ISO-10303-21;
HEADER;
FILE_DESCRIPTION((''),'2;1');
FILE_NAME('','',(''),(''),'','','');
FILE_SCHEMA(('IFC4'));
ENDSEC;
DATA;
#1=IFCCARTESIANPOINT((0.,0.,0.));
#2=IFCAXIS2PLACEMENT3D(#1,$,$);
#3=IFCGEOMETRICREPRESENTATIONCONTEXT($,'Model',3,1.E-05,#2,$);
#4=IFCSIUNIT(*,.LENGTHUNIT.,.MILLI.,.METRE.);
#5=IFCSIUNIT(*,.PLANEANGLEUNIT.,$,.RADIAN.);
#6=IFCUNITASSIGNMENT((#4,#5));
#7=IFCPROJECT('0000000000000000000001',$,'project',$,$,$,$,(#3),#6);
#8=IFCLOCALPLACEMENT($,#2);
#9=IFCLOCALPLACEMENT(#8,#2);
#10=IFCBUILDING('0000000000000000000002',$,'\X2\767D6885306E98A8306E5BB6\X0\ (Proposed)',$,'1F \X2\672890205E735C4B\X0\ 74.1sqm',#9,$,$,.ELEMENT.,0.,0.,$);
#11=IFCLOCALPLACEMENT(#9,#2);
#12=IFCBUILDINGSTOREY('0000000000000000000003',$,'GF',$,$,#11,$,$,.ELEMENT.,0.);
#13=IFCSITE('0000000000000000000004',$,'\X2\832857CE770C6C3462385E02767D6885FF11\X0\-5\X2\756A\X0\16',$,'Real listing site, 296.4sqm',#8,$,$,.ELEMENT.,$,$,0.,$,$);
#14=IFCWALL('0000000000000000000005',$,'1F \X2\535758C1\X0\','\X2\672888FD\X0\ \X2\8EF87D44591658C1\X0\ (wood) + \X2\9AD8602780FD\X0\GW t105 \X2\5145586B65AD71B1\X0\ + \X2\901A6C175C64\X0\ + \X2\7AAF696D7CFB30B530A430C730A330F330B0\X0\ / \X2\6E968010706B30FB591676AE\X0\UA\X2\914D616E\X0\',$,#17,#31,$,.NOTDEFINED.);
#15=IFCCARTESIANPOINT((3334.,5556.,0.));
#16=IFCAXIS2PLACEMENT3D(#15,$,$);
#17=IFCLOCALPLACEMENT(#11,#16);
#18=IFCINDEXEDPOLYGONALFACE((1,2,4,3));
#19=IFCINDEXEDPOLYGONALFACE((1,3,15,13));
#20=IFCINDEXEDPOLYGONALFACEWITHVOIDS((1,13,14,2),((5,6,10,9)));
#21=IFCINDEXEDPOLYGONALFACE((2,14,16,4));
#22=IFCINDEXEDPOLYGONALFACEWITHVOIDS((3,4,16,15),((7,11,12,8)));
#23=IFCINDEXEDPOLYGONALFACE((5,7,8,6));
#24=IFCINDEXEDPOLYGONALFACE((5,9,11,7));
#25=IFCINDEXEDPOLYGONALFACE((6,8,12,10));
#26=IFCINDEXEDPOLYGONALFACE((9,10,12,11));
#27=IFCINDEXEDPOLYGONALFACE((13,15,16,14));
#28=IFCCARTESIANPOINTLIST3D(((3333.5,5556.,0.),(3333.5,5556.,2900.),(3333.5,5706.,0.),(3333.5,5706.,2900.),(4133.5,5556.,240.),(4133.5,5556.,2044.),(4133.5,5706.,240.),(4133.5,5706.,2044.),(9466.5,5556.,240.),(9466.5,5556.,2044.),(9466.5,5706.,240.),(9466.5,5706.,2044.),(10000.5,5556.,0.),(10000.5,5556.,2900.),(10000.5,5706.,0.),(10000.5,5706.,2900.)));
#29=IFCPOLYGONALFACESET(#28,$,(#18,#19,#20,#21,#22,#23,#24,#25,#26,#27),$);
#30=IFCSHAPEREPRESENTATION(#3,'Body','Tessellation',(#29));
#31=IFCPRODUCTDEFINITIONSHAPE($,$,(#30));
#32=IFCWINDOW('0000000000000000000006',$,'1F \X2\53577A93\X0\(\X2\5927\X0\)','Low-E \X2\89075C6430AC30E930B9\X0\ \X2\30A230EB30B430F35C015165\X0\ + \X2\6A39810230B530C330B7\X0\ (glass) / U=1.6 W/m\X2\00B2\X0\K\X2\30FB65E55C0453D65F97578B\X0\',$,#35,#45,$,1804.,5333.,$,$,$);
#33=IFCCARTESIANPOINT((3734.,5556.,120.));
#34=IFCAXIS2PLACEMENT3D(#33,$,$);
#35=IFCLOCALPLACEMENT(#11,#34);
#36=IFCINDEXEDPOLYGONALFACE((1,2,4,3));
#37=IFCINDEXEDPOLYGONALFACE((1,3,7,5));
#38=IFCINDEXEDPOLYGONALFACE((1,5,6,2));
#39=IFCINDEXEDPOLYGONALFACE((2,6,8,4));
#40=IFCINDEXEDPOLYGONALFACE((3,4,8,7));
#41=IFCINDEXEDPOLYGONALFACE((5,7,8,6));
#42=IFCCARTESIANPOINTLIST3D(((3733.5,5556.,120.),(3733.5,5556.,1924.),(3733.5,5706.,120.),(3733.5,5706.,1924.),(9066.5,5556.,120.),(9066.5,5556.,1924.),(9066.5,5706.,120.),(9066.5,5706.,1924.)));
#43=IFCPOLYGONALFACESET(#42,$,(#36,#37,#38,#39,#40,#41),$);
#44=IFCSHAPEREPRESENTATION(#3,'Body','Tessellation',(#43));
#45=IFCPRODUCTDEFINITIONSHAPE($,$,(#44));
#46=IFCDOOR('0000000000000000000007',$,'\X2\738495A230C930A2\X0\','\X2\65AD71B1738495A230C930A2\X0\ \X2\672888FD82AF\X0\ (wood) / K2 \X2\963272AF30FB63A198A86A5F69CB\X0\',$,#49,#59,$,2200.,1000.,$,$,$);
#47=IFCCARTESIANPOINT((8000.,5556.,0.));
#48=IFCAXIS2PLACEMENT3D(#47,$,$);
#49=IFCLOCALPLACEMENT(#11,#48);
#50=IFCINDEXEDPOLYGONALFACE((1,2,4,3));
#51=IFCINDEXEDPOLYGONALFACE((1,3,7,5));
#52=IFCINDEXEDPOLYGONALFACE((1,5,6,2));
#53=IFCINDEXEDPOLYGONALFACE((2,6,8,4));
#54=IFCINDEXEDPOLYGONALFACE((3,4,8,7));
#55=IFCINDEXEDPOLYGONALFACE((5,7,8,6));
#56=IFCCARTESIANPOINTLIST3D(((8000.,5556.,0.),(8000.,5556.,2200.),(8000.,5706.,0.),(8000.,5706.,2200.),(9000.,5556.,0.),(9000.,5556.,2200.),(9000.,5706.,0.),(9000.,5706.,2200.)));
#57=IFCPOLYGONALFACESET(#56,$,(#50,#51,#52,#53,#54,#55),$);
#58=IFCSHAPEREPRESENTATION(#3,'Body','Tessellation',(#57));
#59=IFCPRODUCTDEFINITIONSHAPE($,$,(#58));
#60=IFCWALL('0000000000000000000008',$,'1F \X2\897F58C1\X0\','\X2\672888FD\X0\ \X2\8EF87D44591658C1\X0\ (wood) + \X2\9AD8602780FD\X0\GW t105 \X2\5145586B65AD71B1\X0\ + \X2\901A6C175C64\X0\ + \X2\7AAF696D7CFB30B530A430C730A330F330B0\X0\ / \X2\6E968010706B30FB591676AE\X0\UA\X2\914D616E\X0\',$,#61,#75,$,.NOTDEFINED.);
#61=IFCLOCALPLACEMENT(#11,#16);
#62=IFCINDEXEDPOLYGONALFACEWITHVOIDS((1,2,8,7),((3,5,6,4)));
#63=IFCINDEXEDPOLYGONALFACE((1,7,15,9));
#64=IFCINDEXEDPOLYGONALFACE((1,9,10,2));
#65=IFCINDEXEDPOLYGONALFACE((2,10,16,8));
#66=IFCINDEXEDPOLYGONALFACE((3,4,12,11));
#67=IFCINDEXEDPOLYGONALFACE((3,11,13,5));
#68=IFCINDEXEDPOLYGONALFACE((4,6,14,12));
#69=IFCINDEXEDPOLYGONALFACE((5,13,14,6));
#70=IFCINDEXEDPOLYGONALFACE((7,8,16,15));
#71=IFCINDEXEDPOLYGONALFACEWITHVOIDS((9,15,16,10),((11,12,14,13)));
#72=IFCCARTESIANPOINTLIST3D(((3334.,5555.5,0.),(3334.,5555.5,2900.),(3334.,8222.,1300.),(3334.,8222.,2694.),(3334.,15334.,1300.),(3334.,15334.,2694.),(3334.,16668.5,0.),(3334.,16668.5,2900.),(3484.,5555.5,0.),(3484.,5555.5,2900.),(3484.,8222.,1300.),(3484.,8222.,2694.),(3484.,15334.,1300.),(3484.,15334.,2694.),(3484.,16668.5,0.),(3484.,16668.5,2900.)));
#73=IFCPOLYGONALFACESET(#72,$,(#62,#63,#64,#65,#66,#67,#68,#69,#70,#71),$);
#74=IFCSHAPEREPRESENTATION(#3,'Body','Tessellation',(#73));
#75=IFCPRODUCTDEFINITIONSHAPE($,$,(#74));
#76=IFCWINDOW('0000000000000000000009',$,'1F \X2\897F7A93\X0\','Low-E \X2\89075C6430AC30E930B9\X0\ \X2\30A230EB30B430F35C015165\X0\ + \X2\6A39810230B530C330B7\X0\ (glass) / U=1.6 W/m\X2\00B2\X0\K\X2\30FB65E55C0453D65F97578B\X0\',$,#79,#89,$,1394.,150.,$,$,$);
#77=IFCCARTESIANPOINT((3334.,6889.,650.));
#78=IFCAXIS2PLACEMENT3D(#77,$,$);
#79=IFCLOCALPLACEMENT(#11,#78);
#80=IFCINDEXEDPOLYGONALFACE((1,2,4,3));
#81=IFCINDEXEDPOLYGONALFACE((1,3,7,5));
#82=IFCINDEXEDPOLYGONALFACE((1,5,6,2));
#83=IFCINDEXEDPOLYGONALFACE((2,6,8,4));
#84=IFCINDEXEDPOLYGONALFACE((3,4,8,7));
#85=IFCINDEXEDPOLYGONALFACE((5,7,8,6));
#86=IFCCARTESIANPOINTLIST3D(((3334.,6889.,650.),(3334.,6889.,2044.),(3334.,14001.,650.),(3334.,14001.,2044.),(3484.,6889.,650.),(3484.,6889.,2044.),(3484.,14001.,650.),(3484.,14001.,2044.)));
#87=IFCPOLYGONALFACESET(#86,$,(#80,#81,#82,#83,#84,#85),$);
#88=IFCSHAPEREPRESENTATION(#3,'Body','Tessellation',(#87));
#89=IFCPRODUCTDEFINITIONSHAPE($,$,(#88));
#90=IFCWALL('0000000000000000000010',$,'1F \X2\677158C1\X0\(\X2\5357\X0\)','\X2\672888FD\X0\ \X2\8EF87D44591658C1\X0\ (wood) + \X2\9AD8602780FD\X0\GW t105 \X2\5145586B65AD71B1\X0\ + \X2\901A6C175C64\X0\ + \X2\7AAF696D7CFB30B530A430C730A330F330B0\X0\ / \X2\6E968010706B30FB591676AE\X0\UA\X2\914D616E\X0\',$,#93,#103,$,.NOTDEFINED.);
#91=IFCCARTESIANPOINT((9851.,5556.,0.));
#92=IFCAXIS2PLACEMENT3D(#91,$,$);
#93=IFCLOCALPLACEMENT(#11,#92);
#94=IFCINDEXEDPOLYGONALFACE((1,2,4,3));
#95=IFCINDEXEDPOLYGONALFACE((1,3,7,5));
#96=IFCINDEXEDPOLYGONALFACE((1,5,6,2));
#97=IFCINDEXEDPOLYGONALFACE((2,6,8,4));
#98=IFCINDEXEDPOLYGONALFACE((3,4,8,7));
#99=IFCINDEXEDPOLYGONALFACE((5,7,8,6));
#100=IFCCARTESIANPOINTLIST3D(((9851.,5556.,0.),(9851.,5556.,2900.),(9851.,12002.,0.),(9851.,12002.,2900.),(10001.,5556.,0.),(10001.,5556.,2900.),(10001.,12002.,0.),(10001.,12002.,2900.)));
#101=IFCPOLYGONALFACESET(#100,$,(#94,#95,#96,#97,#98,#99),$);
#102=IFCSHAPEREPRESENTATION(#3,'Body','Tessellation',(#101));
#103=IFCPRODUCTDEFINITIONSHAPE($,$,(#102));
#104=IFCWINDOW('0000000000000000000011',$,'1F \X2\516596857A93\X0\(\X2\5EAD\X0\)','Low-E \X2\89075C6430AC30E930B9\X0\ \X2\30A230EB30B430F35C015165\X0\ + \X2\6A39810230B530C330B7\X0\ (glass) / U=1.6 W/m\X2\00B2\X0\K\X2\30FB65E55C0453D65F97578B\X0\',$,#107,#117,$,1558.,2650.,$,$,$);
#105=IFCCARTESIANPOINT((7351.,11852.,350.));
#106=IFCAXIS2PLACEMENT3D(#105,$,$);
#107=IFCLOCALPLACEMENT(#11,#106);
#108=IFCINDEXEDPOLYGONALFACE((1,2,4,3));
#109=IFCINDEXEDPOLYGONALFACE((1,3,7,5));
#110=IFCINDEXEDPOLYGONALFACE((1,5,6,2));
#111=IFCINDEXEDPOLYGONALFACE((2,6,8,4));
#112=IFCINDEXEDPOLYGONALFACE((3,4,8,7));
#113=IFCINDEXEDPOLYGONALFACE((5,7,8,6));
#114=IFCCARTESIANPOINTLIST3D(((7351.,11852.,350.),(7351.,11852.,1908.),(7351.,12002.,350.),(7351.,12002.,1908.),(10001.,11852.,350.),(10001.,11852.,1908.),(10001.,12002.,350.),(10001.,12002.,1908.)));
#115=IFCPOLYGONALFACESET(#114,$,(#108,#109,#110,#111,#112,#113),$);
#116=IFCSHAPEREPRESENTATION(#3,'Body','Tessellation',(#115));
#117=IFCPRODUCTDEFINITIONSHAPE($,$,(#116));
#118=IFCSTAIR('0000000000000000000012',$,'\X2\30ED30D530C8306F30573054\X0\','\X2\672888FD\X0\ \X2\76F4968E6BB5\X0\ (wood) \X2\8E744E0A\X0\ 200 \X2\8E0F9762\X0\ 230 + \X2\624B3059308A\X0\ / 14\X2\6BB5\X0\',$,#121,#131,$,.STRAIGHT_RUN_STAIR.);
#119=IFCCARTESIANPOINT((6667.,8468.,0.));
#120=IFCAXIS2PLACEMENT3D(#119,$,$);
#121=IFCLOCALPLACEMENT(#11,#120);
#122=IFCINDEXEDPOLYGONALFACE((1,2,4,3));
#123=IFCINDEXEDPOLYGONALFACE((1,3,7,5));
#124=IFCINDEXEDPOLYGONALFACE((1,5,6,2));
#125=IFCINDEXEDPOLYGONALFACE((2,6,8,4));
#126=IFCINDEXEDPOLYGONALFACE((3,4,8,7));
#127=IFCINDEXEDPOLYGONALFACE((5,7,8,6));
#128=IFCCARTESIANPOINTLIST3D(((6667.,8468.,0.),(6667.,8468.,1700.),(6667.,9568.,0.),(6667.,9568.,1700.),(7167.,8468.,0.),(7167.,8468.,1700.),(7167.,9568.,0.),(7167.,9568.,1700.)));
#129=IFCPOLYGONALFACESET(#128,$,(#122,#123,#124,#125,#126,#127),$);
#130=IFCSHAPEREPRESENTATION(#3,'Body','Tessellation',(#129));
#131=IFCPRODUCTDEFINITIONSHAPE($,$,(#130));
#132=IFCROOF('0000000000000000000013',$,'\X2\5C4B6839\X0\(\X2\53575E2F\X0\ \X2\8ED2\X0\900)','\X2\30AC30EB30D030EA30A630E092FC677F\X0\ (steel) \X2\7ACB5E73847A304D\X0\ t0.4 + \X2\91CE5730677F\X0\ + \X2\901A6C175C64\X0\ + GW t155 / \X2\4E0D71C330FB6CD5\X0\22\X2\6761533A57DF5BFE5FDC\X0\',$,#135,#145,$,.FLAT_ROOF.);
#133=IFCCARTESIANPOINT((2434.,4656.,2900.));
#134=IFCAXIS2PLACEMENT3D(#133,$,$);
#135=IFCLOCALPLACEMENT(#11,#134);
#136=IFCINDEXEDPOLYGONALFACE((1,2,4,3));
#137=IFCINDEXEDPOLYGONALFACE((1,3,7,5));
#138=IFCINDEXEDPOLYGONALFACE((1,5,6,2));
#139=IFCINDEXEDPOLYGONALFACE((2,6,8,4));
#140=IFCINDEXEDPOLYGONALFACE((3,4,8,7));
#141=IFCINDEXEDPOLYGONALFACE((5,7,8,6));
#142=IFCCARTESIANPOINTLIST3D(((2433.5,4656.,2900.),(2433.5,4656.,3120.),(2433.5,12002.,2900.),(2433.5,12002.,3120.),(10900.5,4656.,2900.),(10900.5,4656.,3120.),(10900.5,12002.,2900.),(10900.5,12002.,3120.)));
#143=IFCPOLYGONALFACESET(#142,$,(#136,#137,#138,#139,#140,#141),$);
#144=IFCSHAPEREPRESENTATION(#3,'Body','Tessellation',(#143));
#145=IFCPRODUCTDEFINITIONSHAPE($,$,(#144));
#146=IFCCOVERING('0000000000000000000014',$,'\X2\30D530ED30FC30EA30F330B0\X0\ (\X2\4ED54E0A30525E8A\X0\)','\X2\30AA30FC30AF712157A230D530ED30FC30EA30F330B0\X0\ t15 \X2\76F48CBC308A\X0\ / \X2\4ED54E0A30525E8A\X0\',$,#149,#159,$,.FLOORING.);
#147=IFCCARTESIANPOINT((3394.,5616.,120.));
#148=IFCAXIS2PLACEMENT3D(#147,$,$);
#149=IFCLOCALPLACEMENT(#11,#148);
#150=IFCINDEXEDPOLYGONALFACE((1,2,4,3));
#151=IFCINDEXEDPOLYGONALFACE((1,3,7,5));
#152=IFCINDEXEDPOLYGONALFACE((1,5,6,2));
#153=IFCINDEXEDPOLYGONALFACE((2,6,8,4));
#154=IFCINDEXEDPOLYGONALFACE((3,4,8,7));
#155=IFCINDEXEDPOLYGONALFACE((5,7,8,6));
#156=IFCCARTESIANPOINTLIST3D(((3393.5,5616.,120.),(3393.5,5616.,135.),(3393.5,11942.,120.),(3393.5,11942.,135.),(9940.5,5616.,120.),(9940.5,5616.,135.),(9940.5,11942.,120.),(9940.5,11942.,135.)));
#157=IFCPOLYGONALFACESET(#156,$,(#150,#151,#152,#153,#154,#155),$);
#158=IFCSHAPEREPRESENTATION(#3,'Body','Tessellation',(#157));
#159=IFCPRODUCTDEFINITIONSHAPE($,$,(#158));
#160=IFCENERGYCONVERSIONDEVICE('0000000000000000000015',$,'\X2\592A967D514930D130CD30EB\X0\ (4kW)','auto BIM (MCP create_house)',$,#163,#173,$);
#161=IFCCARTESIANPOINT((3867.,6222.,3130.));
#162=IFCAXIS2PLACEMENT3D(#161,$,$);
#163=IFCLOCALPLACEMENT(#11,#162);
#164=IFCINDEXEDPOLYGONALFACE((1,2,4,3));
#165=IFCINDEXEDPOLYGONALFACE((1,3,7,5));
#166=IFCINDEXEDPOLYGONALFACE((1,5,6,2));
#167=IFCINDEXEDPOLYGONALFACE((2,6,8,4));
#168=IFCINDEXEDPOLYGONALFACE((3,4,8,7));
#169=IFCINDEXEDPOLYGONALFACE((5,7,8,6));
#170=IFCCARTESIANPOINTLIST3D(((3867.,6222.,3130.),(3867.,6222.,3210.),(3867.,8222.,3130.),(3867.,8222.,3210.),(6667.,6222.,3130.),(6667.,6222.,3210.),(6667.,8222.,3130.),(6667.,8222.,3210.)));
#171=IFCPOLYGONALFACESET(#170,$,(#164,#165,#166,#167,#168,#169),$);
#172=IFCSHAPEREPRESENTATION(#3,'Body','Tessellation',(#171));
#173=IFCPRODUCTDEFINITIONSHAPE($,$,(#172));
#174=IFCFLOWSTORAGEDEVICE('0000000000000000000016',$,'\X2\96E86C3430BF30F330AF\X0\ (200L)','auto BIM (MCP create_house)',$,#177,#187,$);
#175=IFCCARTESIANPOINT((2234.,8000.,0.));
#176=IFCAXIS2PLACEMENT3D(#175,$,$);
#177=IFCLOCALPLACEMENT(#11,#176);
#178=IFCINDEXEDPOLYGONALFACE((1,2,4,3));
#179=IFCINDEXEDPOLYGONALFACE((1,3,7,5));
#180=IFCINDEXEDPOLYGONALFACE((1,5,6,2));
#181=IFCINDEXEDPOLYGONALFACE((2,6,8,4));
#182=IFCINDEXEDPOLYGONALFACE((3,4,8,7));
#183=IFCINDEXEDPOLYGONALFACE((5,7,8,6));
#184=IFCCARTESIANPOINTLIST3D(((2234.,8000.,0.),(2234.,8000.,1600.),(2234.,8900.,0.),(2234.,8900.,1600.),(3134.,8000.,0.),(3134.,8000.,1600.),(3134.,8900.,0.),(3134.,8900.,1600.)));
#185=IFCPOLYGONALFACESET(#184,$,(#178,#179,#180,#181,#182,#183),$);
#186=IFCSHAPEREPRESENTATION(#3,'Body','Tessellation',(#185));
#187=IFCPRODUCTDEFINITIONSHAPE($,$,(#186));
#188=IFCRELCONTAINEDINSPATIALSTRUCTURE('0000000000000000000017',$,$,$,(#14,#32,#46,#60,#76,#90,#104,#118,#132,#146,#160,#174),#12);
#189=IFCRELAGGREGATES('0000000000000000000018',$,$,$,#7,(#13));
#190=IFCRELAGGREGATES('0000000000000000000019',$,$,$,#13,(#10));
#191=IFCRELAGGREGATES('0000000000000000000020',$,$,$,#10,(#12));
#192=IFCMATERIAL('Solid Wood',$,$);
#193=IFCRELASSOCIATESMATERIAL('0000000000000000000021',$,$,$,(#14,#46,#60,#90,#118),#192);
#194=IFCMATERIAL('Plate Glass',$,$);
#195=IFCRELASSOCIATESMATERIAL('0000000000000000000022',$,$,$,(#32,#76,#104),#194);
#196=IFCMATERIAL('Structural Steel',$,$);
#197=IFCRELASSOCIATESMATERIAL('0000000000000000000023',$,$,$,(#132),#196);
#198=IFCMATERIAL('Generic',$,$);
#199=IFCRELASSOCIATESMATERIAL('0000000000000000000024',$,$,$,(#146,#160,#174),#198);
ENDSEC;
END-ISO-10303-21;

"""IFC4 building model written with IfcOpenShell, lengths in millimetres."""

from ifc_helpers import new_model, si_unit, frame, frame_2d, origin, place, context, project, spatial, rectangle, extrude, material, element, fill, save


model = new_model("IFC4")

# Units and contexts
model_context = context("Model", 3, precision=1e-05, world=origin())
ifc_project = project(units=[si_unit("LENGTHUNIT", "METRE", prefix="MILLI"), si_unit("PLANEANGLEUNIT", "RADIAN")], contexts=[model_context])

# Site, building, storey
site_placement = place(None, origin())
site = spatial("IfcSite", under=ifc_project, at=site_placement, Name="茨城県水戸市白梅１-5番16", ObjectType="Real listing site, 296.4sqm", CompositionType="ELEMENT", RefElevation=0.0)
building_placement = place(site_placement, origin())
building = spatial("IfcBuilding", under=site, at=building_placement, Name="白梅の風の家 (Proposed)", ObjectType="1F 木造平屋 74.1sqm", CompositionType="ELEMENT", ElevationOfRefHeight=0.0, ElevationOfTerrain=0.0)
storey_placement = place(building_placement, origin())
storey = spatial("IfcBuildingStorey", under=building, at=storey_placement, Name="GF", CompositionType="ELEMENT", Elevation=0.0)

# Shared definitions
ifc_material_1 = material(Name="Solid Wood")

# Wall, openings, window, door
wall_1_placement = place(storey_placement, frame((3334.0, 5556.0, 0.0)))
wall_1 = element("IfcWall", 1, at=wall_1_placement, inside=storey, material=ifc_material_1, Name="1F 南壁", Description="木製 軸組外壁 (wood) + 高性能GW t105 充填断熱 + 通気層 + 窯業系サイディング / 準耐火・外皮UA配慮", PredefinedType="NOTDEFINED", context=model_context, shape_type="SweptSolid", body=[
    extrude(rectangle(XDim=6667.0, YDim=150.0, at=frame_2d((3333.0, 75.0))), frame((3334.0, 5556.0, 0.0)), (0.0, 0.0, 1.0), 2900.0),
])
opening_1_placement = place(storey_placement, frame((3734.0, 5556.0, 120.0)))
opening_1 = element("IfcOpeningElement", 2, at=opening_1_placement, cuts=wall_1, PredefinedType="NOTDEFINED", context=model_context, shape_type="SweptSolid", body=[
    extrude(rectangle(XDim=5333.0, YDim=150.0, at=frame_2d((2666.0, 75.0))), frame((3734.0, 5556.0, 120.0)), (0.0, 0.0, 1.0), 1804.0),
])
opening_2_placement = place(storey_placement, frame((8000.0, 5556.0, 0.0)))
opening_2 = element("IfcOpeningElement", 3, at=opening_2_placement, cuts=wall_1, PredefinedType="NOTDEFINED", context=model_context, shape_type="SweptSolid", body=[
    extrude(rectangle(XDim=1000.0, YDim=150.0, at=frame_2d((500.0, 75.0))), frame((8000.0, 5556.0, 0.0)), (0.0, 0.0, 1.0), 2200.0),
])
ifc_material_2 = material(Name="Plate Glass")
window_1_placement = place(storey_placement, frame((3734.0, 5556.0, 120.0)))
window_1 = element("IfcWindow", 4, at=window_1_placement, inside=storey, material=ifc_material_2, Name="1F 南窓(大)", Description="Low-E 複層ガラス アルゴン封入 + 樹脂サッシ (glass) / U=1.6 W/m²K・日射取得型", OverallHeight=1804.0, OverallWidth=5333.0, context=model_context, shape_type="SweptSolid", body=[
    extrude(rectangle(XDim=5333.0, YDim=150.0, at=frame_2d((2666.0, 75.0))), frame((3734.0, 5556.0, 120.0)), (0.0, 0.0, 1.0), 1804.0),
])
fill(opening_1, window_1)
door_1_placement = place(storey_placement, frame((8000.0, 5556.0, 0.0)))
door_1 = element("IfcDoor", 5, at=door_1_placement, inside=storey, material=ifc_material_1, Name="玄関ドア", Description="断熱玄関ドア 木製芯 (wood) / K2 防犯・採風機構", OverallHeight=2200.0, OverallWidth=1000.0, context=model_context, shape_type="SweptSolid", body=[
    extrude(rectangle(XDim=1000.0, YDim=150.0, at=frame_2d((500.0, 75.0))), frame((8000.0, 5556.0, 0.0)), (0.0, 0.0, 1.0), 2200.0),
])
fill(opening_2, door_1)

# Walls, openings, windows
wall_2_placement = place(storey_placement, frame((3334.0, 5556.0, 0.0)))
wall_2 = element("IfcWall", 6, at=wall_2_placement, inside=storey, material=ifc_material_1, Name="1F 西壁", Description="木製 軸組外壁 (wood) + 高性能GW t105 充填断熱 + 通気層 + 窯業系サイディング / 準耐火・外皮UA配慮", PredefinedType="NOTDEFINED", context=model_context, shape_type="SweptSolid", body=[
    extrude(rectangle(XDim=150.0, YDim=11113.0, at=frame_2d((75.0, 5556.0))), frame((3334.0, 5556.0, 0.0)), (0.0, 0.0, 1.0), 2900.0),
])
opening_3_placement = place(storey_placement, frame((3334.0, 6889.0, 650.0)))
opening_3 = element("IfcOpeningElement", 7, at=opening_3_placement, cuts=wall_2, PredefinedType="NOTDEFINED", context=model_context, shape_type="SweptSolid", body=[
    extrude(rectangle(XDim=150.0, YDim=7112.0, at=frame_2d((75.0, 3556.0))), frame((3334.0, 6889.0, 650.0)), (0.0, 0.0, 1.0), 1394.0),
])
window_2_placement = place(storey_placement, frame((3334.0, 6889.0, 650.0)))
window_2 = element("IfcWindow", 8, at=window_2_placement, inside=storey, material=ifc_material_2, Name="1F 西窓", Description="Low-E 複層ガラス アルゴン封入 + 樹脂サッシ (glass) / U=1.6 W/m²K・日射取得型", OverallHeight=1394.0, OverallWidth=150.0, context=model_context, shape_type="SweptSolid", body=[
    extrude(rectangle(XDim=150.0, YDim=7112.0, at=frame_2d((75.0, 3556.0))), frame((3334.0, 6889.0, 650.0)), (0.0, 0.0, 1.0), 1394.0),
])
fill(opening_3, window_2)
wall_3_placement = place(storey_placement, frame((9851.0, 5556.0, 0.0)))
wall_3 = element("IfcWall", 9, at=wall_3_placement, inside=storey, material=ifc_material_1, Name="1F 東壁(南)", Description="木製 軸組外壁 (wood) + 高性能GW t105 充填断熱 + 通気層 + 窯業系サイディング / 準耐火・外皮UA配慮", PredefinedType="NOTDEFINED", context=model_context, shape_type="SweptSolid", body=[
    extrude(rectangle(XDim=150.0, YDim=6446.0, at=frame_2d((75.0, 3223.0))), frame((9851.0, 5556.0, 0.0)), (0.0, 0.0, 1.0), 2900.0),
])
opening_4_placement = place(storey_placement, frame((7351.0, 11852.0, 350.0)))
opening_4 = element("IfcOpeningElement", 10, at=opening_4_placement, cuts=wall_3, PredefinedType="NOTDEFINED", context=model_context, shape_type="SweptSolid", body=[
    extrude(rectangle(XDim=2650.0, YDim=150.0, at=frame_2d((1325.0, 75.0))), frame((7351.0, 11852.0, 350.0)), (0.0, 0.0, 1.0), 1558.0),
])
window_3_placement = place(storey_placement, frame((7351.0, 11852.0, 350.0)))
window_3 = element("IfcWindow", 11, at=window_3_placement, inside=storey, material=ifc_material_2, Name="1F 入隅窓(庭)", Description="Low-E 複層ガラス アルゴン封入 + 樹脂サッシ (glass) / U=1.6 W/m²K・日射取得型", OverallHeight=1558.0, OverallWidth=2650.0, context=model_context, shape_type="SweptSolid", body=[
    extrude(rectangle(XDim=2650.0, YDim=150.0, at=frame_2d((1325.0, 75.0))), frame((7351.0, 11852.0, 350.0)), (0.0, 0.0, 1.0), 1558.0),
])
fill(opening_4, window_3)

# Stair
stair_placement = place(storey_placement, frame((6667.0, 8468.0, 0.0)))
element("IfcStair", 12, at=stair_placement, inside=storey, material=ifc_material_1, Name="ロフトはしご", Description="木製 直階段 (wood) 蹴上 200 踏面 230 + 手すり / 14段", PredefinedType="STRAIGHT_RUN_STAIR", context=model_context, shape_type="SweptSolid", body=[
    extrude(rectangle(XDim=500.0, YDim=1100.0, at=frame_2d((250.0, 550.0))), frame((6667.0, 8468.0, 0.0)), (0.0, 0.0, 1.0), 1700.0),
])

# Roof
ifc_material_3 = material(Name="Structural Steel")
roof_placement = place(storey_placement, frame((2434.0, 4656.0, 2900.0)))
element("IfcRoof", 13, at=roof_placement, inside=storey, material=ifc_material_3, Name="屋根(南帯 軒900)", Description="ガルバリウム鋼板 (steel) 立平葺き t0.4 + 野地板 + 通気層 + GW t155 / 不燃・法22条区域対応", PredefinedType="FLAT_ROOF", context=model_context, shape_type="SweptSolid", body=[
    extrude(rectangle(XDim=8467.0, YDim=7346.0, at=frame_2d((4233.0, 3673.0))), frame((2434.0, 4656.0, 2900.0)), (0.0, 0.0, 1.0), 220.0),
])

# Covering
ifc_material_4 = material(Name="Generic")
covering_placement = place(storey_placement, frame((3394.0, 5616.0, 120.0)))
element("IfcCovering", 14, at=covering_placement, inside=storey, material=ifc_material_4, Name="フローリング (仕上げ床)", Description="オーク無垢フローリング t15 直貼り / 仕上げ床", PredefinedType="FLOORING", context=model_context, shape_type="SweptSolid", body=[
    extrude(rectangle(XDim=6547.0, YDim=6326.0, at=frame_2d((3273.0, 3163.0))), frame((3394.0, 5616.0, 120.0)), (0.0, 0.0, 1.0), 15.0),
])

# Energy conversion device
energy_conversion_device_placement = place(storey_placement, frame((3867.0, 6222.0, 3130.0)))
element("IfcEnergyConversionDevice", 15, at=energy_conversion_device_placement, inside=storey, material=ifc_material_4, Name="太陽光パネル (4kW)", Description="auto BIM (MCP create_house)", context=model_context, shape_type="SweptSolid", body=[
    extrude(rectangle(XDim=2800.0, YDim=2000.0, at=frame_2d((1400.0, 1000.0))), frame((3867.0, 6222.0, 3130.0)), (0.0, 0.0, 1.0), 80.0),
])

# Flow storage device
flow_storage_device_placement = place(storey_placement, frame((2234.0, 8000.0, 0.0)))
element("IfcFlowStorageDevice", 16, at=flow_storage_device_placement, inside=storey, material=ifc_material_4, Name="雨水タンク (200L)", Description="auto BIM (MCP create_house)", context=model_context, shape_type="SweptSolid", body=[
    extrude(rectangle(XDim=900.0, YDim=900.0, at=frame_2d((450.0, 450.0))), frame((2234.0, 8000.0, 0.0)), (0.0, 0.0, 1.0), 1600.0),
])

save(model, "model.ifc")
